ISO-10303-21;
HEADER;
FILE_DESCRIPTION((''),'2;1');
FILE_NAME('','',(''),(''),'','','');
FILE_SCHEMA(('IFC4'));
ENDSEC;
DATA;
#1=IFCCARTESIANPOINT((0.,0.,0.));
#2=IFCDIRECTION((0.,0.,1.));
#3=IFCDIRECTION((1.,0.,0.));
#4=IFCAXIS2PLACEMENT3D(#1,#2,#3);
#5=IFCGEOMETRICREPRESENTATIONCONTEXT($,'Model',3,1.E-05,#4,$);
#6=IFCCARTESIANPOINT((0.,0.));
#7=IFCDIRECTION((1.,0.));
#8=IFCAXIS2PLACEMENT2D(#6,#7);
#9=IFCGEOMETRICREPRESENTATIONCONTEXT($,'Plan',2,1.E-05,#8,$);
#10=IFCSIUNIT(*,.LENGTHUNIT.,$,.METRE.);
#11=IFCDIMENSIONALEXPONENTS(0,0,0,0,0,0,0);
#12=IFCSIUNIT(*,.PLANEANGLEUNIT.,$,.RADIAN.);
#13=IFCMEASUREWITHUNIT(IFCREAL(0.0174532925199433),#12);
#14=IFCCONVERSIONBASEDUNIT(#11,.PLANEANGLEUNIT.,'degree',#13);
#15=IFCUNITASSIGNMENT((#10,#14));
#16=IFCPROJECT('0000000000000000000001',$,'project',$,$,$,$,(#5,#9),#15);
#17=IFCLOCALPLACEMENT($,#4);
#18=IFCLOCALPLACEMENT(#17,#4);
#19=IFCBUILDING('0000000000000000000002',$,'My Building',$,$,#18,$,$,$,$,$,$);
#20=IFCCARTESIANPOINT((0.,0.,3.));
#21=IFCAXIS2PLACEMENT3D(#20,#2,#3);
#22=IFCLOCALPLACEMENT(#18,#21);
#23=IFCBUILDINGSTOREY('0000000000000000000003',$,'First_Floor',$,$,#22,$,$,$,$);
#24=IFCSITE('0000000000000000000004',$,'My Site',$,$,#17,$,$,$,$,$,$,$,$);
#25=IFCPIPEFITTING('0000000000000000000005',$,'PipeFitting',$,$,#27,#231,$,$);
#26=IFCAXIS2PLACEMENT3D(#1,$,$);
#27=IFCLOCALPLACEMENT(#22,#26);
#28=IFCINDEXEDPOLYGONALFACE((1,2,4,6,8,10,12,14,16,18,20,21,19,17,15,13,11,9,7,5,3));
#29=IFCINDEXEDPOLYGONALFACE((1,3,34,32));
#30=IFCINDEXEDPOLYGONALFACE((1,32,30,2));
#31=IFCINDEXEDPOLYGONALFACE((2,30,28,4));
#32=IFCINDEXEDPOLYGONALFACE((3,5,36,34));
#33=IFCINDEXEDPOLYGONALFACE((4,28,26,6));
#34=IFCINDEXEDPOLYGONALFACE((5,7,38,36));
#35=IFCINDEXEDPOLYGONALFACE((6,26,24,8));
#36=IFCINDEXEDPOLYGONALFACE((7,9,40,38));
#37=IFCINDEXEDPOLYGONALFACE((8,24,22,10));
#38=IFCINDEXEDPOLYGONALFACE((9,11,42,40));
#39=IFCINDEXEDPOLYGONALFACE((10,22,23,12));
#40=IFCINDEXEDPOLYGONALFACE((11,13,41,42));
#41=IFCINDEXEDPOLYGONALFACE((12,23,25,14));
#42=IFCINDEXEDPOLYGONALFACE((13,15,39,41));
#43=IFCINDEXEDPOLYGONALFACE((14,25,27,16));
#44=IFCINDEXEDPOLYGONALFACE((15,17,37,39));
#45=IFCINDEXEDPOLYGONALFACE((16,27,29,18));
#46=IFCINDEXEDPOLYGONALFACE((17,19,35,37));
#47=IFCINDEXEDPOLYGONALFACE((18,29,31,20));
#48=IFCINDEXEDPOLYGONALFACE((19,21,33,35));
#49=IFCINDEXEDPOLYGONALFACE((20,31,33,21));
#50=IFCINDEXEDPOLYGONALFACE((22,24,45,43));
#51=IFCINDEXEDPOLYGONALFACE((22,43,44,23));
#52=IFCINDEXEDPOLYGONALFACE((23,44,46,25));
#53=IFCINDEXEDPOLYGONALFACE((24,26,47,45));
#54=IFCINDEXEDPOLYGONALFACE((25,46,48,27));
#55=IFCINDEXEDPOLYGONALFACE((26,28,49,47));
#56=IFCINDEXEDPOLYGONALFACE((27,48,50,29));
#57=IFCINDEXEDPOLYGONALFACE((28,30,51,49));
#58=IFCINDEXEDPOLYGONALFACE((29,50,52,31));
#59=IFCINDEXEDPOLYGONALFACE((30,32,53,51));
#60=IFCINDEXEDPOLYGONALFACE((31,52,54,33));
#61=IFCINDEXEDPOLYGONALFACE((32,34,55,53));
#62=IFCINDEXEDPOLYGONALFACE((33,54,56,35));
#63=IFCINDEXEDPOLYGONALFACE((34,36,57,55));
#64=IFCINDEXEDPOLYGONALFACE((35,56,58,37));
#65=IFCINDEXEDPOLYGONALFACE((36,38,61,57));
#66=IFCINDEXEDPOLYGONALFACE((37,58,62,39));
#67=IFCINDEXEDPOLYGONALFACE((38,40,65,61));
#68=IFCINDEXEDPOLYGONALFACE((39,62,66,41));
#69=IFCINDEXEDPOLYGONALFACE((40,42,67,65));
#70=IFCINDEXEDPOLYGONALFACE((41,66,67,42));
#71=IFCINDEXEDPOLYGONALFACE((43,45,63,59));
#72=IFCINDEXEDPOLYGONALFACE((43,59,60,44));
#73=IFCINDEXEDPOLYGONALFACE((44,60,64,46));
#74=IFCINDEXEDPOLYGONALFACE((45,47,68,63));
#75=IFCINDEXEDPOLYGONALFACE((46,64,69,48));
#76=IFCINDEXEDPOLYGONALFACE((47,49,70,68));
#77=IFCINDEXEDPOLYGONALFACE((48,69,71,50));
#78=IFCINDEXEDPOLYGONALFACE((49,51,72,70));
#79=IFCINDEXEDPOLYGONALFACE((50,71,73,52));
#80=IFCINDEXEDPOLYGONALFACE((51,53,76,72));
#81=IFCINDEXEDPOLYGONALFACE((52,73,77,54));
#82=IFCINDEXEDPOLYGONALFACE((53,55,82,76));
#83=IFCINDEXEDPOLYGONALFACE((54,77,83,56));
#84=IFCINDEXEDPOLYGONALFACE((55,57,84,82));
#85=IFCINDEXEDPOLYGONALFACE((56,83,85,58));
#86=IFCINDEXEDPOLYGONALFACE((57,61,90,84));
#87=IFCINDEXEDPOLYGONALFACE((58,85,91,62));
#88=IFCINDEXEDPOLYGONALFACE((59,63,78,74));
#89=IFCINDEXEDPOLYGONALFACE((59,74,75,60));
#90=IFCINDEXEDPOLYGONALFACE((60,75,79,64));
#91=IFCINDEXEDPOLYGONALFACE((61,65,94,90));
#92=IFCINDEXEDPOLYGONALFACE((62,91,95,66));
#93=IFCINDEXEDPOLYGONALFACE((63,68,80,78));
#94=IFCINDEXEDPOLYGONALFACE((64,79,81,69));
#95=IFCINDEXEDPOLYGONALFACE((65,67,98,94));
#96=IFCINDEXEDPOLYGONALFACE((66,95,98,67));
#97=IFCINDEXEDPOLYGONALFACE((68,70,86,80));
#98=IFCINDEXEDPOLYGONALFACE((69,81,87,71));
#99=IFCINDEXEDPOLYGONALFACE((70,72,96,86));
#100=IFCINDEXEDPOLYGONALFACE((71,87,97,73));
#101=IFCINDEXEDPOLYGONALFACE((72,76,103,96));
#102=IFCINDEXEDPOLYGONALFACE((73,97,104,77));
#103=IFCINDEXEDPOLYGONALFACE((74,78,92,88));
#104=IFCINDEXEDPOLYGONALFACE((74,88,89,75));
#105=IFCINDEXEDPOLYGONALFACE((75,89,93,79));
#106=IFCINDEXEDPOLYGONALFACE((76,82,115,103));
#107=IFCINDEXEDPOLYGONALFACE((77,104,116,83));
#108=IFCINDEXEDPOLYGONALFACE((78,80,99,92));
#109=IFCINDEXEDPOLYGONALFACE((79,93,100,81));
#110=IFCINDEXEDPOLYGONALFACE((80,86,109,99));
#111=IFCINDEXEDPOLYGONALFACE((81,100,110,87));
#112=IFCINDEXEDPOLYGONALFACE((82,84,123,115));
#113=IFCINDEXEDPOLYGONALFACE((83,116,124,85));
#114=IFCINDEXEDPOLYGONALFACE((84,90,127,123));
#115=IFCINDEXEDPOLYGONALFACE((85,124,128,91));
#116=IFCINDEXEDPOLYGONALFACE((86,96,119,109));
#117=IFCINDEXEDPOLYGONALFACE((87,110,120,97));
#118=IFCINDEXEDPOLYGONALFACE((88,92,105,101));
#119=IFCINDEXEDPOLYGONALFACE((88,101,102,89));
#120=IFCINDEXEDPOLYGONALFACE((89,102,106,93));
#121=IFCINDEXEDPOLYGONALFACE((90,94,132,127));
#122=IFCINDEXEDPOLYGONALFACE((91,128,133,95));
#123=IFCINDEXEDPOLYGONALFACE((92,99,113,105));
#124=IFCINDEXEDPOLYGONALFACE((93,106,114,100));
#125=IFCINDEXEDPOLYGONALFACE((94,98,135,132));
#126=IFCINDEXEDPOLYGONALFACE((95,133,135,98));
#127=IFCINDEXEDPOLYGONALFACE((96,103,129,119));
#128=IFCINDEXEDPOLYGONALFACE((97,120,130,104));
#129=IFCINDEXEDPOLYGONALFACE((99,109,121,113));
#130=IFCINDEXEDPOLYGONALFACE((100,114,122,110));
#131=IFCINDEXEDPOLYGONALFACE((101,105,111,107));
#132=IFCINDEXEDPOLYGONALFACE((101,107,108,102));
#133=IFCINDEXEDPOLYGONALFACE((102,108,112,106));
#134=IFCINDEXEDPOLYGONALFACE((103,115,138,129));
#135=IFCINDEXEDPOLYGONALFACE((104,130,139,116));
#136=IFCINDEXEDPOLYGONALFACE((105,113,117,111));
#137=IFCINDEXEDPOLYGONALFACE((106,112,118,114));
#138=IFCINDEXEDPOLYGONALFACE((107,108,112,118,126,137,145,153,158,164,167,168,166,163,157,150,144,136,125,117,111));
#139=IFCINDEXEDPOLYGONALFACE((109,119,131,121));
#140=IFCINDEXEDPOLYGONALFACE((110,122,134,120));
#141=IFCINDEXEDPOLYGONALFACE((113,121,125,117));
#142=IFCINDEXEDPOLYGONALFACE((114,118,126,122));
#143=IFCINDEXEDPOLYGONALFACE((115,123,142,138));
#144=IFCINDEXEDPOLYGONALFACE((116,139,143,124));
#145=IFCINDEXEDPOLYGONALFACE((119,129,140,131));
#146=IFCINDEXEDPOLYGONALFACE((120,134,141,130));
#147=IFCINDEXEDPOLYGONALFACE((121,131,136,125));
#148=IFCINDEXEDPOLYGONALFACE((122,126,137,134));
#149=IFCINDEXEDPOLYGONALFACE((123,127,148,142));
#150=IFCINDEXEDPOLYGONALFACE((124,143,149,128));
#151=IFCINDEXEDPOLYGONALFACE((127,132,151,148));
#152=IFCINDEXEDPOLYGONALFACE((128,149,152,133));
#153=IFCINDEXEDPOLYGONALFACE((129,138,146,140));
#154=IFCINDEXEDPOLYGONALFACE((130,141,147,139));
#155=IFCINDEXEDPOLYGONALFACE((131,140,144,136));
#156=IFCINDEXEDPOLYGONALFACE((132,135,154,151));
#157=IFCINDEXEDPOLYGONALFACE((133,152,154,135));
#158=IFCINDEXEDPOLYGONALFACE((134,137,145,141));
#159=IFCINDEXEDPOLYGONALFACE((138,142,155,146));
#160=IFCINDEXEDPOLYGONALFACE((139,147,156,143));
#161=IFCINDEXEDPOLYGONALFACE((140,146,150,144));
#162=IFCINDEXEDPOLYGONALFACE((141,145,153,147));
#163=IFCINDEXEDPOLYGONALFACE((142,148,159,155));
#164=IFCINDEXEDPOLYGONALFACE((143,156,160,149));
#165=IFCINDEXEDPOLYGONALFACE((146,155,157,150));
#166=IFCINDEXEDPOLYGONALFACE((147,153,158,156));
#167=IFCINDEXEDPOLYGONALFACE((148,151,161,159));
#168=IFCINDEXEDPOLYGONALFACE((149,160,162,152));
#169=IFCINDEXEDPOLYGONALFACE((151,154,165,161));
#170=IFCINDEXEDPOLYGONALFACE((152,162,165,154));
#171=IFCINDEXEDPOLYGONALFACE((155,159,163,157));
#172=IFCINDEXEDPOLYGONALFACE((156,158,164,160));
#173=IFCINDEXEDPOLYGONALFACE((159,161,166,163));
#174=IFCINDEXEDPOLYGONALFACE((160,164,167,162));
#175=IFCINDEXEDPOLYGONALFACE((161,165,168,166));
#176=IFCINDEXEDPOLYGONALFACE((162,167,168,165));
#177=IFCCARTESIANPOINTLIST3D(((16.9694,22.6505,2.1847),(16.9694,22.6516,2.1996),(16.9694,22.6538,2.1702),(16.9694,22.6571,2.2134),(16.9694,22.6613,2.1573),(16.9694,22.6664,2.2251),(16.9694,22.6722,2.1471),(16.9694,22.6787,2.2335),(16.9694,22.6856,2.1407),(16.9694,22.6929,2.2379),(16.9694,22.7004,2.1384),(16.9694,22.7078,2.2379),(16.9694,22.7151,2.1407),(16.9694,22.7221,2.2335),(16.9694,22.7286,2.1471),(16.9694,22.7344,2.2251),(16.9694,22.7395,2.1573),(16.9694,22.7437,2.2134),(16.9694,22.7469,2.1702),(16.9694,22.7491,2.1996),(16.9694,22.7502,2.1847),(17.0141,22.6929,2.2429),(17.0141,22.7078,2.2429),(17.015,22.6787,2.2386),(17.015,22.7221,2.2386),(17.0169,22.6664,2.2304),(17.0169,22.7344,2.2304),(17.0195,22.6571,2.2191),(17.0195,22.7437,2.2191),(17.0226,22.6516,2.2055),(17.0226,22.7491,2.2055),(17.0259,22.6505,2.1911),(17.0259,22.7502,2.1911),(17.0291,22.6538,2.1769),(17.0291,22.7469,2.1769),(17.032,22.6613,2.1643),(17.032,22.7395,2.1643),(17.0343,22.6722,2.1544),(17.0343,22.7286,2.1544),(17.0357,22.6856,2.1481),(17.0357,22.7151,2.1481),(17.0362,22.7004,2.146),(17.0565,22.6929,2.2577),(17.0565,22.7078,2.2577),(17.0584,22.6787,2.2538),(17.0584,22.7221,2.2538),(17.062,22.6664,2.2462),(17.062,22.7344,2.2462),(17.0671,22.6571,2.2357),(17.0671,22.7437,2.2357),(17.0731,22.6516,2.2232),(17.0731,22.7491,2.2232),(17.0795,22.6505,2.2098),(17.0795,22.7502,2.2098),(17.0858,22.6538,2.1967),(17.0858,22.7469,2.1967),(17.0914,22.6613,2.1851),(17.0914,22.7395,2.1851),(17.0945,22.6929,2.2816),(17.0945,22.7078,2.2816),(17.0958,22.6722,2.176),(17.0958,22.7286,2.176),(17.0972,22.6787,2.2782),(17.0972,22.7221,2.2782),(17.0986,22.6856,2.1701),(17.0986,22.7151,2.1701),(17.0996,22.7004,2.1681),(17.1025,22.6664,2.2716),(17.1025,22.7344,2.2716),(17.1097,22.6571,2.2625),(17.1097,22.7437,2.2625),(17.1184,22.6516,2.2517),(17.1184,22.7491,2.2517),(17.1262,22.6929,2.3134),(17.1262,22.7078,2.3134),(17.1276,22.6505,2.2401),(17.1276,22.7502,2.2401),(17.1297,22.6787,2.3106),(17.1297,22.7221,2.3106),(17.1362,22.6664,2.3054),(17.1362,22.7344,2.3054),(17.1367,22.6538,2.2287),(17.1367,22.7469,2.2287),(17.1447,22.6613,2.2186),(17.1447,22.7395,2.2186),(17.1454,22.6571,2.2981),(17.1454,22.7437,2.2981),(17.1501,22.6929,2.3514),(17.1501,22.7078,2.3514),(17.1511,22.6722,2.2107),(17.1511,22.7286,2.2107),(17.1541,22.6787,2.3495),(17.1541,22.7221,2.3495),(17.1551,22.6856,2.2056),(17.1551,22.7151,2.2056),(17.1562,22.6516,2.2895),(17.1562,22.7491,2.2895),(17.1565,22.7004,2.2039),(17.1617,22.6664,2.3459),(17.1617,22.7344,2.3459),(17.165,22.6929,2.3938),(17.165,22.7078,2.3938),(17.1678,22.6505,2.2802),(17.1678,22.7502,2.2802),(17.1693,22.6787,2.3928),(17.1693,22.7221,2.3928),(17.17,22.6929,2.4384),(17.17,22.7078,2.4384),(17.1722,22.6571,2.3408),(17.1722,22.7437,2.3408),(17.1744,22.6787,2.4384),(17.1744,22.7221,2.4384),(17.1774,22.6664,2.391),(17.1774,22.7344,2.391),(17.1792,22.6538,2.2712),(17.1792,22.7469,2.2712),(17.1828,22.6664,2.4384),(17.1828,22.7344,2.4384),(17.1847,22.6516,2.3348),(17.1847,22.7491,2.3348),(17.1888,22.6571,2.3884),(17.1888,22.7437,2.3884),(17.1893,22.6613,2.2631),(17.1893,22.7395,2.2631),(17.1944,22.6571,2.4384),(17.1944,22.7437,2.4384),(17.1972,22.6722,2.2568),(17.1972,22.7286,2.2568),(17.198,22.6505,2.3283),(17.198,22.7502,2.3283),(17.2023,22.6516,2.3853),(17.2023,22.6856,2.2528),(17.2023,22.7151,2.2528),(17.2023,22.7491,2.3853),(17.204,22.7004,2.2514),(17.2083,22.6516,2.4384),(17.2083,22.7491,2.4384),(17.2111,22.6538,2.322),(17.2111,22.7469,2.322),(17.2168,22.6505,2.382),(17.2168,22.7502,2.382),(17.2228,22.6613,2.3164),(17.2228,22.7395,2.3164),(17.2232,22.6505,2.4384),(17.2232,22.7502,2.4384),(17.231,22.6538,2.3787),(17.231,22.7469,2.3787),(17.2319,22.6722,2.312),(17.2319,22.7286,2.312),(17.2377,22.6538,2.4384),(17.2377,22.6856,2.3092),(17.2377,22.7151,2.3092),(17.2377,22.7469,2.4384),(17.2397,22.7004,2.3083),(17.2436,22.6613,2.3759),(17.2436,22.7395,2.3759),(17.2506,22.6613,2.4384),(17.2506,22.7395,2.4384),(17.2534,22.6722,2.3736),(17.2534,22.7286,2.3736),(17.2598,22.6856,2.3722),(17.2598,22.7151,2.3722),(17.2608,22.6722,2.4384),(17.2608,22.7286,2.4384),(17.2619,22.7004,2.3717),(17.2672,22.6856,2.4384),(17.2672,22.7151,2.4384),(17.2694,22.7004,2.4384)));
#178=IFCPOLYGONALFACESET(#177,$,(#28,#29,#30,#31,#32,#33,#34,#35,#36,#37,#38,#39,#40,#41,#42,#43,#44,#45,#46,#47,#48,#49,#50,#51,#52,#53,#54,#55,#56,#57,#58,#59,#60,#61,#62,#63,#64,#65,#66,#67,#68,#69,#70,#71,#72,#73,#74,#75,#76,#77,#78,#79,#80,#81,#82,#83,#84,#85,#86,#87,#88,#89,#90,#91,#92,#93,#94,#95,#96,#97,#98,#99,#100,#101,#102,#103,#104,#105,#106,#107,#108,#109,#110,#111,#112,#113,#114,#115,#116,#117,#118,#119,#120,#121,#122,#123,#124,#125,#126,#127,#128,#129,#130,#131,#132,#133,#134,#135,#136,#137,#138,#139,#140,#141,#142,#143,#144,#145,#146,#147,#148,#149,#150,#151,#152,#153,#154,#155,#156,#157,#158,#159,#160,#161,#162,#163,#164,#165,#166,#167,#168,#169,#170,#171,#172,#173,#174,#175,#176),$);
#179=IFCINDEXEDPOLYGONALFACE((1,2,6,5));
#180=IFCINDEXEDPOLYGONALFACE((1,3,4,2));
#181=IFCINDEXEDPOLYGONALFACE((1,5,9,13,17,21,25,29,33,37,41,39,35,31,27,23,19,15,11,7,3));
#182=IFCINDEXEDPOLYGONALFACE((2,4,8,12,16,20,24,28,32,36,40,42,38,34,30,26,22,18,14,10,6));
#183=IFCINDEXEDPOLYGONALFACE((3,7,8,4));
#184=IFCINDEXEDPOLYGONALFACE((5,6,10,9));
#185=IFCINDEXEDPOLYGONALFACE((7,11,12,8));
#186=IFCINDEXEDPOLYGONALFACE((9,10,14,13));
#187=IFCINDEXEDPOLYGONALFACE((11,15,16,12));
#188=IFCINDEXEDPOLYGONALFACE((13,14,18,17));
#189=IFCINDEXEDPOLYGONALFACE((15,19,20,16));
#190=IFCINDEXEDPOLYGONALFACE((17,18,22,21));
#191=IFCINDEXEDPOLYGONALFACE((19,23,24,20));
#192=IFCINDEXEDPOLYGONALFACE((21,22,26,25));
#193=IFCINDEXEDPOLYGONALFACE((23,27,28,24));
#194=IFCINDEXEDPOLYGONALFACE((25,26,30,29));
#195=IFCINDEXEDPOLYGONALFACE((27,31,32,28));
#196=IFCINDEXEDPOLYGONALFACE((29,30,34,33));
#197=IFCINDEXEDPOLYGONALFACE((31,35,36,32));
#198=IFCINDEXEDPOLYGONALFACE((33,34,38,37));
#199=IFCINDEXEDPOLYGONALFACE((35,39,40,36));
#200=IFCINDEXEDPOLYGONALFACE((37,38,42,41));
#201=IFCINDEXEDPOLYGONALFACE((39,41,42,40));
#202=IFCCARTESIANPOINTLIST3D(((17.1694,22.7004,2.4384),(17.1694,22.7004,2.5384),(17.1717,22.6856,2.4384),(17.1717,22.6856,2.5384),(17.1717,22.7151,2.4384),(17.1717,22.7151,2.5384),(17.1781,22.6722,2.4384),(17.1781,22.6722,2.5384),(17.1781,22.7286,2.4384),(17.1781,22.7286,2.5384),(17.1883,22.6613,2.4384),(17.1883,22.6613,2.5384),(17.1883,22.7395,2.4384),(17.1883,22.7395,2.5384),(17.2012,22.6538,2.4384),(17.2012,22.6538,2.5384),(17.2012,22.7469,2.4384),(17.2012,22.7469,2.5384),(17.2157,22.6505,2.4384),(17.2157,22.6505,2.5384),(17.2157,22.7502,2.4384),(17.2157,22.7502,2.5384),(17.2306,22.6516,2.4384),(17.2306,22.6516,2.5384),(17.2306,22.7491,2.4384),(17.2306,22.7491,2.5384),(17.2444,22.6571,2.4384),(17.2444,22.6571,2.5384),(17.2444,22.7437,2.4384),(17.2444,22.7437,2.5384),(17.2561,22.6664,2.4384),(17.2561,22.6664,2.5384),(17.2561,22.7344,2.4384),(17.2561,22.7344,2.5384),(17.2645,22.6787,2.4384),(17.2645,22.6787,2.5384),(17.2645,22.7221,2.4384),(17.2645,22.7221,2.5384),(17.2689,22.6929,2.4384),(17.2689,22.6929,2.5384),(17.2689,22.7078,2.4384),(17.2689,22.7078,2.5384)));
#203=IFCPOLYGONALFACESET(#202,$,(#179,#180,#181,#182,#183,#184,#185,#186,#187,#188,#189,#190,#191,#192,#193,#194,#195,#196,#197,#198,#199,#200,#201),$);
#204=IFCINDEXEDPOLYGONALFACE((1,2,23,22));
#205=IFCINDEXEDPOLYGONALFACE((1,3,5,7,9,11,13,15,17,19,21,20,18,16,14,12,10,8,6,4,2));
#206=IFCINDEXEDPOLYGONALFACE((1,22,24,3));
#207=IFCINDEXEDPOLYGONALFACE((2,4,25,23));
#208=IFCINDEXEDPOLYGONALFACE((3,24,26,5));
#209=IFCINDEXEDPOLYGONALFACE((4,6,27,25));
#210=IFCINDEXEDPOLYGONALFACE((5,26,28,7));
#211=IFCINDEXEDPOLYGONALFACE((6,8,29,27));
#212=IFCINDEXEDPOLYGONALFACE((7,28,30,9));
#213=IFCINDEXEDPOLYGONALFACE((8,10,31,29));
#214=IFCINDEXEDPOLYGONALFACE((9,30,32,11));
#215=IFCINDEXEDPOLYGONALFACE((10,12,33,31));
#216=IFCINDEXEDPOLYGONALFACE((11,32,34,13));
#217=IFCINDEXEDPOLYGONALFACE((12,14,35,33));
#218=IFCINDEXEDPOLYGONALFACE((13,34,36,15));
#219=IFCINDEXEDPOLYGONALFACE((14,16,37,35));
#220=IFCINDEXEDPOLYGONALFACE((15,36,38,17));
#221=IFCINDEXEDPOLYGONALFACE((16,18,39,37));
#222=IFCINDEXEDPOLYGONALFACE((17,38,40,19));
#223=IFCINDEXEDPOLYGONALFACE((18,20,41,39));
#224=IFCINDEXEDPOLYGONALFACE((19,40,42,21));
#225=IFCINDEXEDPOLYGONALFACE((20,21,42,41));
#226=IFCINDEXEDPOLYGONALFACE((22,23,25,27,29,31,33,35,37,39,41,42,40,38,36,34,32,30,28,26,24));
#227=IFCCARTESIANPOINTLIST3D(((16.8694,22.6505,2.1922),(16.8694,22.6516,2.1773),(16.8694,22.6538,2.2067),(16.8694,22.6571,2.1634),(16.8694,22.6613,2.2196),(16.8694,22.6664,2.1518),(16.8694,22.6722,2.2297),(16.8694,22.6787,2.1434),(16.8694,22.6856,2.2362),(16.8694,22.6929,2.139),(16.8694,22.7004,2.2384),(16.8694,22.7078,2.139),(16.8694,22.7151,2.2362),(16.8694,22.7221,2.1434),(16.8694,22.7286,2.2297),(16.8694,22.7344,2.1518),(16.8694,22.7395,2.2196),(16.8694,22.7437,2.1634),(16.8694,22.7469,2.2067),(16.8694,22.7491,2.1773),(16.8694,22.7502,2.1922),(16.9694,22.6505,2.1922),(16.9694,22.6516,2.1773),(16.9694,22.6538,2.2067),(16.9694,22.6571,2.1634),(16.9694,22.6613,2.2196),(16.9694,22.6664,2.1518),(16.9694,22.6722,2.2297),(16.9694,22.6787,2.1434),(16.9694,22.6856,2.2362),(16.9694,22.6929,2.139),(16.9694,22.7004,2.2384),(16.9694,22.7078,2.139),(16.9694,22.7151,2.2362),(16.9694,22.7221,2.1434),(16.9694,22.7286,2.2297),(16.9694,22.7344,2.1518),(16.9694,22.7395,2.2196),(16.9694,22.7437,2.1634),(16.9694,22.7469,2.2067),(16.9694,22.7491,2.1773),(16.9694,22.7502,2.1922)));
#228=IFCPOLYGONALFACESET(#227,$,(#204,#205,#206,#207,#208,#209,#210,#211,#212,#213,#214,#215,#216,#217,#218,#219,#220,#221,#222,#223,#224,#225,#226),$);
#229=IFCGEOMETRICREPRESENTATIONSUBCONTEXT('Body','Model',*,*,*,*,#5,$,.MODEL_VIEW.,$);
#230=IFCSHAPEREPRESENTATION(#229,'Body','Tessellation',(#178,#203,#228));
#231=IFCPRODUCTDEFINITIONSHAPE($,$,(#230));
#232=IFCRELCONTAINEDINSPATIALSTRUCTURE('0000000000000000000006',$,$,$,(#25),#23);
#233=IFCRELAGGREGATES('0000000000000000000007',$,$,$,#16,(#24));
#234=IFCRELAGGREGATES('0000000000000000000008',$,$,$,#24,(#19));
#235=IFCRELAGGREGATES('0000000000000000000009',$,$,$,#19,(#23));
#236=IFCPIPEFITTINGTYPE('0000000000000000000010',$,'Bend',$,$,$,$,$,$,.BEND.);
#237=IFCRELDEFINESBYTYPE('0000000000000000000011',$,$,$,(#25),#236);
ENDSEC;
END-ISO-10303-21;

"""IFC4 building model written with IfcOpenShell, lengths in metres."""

from ifc_helpers import new_model, entity, si_unit, converted_unit, frame, origin_with_axes, origin_2d_with_axis, place, context, subcontext, project, spatial, circle, extrude, source, transform, mapped, type_object, type_shapes, element, save


model = new_model("IFC4")

# Units and contexts
model_context = context("Model", 3, precision=1e-05, world=origin_with_axes())
plan_context = context("Plan", 2, precision=1e-05, world=origin_2d_with_axis())
body_context = subcontext(model_context, "Body", "Model", "MODEL_VIEW")
ifc_project = project(units=[si_unit("LENGTHUNIT", "METRE"), converted_unit("PLANEANGLEUNIT", "degree", entity("IfcReal", 0.0174532925199433), si_unit("PLANEANGLEUNIT", "RADIAN"), dimensions=[0, 0, 0, 0, 0, 0, 0])], contexts=[model_context, plan_context])

# Site, building, storey
site_placement = place(None, origin_with_axes())
site = spatial("IfcSite", under=ifc_project, at=site_placement, Name="My Site")
building_placement = place(site_placement, origin_with_axes())
building = spatial("IfcBuilding", under=site, at=building_placement, Name="My Building")
storey_placement = place(building_placement, frame((0.0, 0.0, 3.0), z_axis=(0.0, 0.0, 1.0), x_axis=(1.0, 0.0, 0.0)))
storey = spatial("IfcBuildingStorey", under=building, at=storey_placement, Name="First_Floor")

# Pipe fitting
pipe_fitting_type = type_object("IfcPipeFittingType", Name="Bend", PredefinedType="BEND")
shared_shape = source(origin_with_axes(), body_context, "Body", "SolidModel", [
    entity("IfcSweptDiskSolid", entity("IfcIndexedPolyCurve", entity("IfcCartesianPointList3D", [[0.0, 0.0, -0.1], [0.0732, 0.0, -0.2768], [0.25, 0.0, -0.35]]), [entity("IfcArcIndex", [1, 2, 3])]), 0.05),
    extrude(circle(Radius=0.05), origin_with_axes(), (0.0, 0.0, -1.0), 0.1),
    extrude(circle(Radius=0.05), frame((0.25, 0.0, -0.35), z_axis=(1.0, 0.0, 0.0), x_axis=(0.0, 0.0, 1.0)), (0.0, 0.0, 1.0), 0.1),
])
type_shapes(pipe_fitting_type, [shared_shape])
for number, where, z_axis, x_axis, name in (
    (1, (17.2194, 22.7004, 2.5384), (0.0, 0.0, 1.0), (-1.0, 0.0, 0.0), "PipeFitting"),
):
    element("IfcPipeFitting", number, at=place(storey_placement, frame(where, z_axis=z_axis, x_axis=x_axis)), inside=storey, type_object=pipe_fitting_type, Name=name, context=body_context, shape_type="MappedRepresentation", body=[
        mapped(shared_shape, transform((0.0, 0.0, 0.0), x_axis=(1.0, 0.0, 0.0), y_axis=(0.0, 1.0, 0.0), z_axis=(0.0, 0.0, 1.0), scale=1.0)),
    ])

save(model, "model.ifc")
